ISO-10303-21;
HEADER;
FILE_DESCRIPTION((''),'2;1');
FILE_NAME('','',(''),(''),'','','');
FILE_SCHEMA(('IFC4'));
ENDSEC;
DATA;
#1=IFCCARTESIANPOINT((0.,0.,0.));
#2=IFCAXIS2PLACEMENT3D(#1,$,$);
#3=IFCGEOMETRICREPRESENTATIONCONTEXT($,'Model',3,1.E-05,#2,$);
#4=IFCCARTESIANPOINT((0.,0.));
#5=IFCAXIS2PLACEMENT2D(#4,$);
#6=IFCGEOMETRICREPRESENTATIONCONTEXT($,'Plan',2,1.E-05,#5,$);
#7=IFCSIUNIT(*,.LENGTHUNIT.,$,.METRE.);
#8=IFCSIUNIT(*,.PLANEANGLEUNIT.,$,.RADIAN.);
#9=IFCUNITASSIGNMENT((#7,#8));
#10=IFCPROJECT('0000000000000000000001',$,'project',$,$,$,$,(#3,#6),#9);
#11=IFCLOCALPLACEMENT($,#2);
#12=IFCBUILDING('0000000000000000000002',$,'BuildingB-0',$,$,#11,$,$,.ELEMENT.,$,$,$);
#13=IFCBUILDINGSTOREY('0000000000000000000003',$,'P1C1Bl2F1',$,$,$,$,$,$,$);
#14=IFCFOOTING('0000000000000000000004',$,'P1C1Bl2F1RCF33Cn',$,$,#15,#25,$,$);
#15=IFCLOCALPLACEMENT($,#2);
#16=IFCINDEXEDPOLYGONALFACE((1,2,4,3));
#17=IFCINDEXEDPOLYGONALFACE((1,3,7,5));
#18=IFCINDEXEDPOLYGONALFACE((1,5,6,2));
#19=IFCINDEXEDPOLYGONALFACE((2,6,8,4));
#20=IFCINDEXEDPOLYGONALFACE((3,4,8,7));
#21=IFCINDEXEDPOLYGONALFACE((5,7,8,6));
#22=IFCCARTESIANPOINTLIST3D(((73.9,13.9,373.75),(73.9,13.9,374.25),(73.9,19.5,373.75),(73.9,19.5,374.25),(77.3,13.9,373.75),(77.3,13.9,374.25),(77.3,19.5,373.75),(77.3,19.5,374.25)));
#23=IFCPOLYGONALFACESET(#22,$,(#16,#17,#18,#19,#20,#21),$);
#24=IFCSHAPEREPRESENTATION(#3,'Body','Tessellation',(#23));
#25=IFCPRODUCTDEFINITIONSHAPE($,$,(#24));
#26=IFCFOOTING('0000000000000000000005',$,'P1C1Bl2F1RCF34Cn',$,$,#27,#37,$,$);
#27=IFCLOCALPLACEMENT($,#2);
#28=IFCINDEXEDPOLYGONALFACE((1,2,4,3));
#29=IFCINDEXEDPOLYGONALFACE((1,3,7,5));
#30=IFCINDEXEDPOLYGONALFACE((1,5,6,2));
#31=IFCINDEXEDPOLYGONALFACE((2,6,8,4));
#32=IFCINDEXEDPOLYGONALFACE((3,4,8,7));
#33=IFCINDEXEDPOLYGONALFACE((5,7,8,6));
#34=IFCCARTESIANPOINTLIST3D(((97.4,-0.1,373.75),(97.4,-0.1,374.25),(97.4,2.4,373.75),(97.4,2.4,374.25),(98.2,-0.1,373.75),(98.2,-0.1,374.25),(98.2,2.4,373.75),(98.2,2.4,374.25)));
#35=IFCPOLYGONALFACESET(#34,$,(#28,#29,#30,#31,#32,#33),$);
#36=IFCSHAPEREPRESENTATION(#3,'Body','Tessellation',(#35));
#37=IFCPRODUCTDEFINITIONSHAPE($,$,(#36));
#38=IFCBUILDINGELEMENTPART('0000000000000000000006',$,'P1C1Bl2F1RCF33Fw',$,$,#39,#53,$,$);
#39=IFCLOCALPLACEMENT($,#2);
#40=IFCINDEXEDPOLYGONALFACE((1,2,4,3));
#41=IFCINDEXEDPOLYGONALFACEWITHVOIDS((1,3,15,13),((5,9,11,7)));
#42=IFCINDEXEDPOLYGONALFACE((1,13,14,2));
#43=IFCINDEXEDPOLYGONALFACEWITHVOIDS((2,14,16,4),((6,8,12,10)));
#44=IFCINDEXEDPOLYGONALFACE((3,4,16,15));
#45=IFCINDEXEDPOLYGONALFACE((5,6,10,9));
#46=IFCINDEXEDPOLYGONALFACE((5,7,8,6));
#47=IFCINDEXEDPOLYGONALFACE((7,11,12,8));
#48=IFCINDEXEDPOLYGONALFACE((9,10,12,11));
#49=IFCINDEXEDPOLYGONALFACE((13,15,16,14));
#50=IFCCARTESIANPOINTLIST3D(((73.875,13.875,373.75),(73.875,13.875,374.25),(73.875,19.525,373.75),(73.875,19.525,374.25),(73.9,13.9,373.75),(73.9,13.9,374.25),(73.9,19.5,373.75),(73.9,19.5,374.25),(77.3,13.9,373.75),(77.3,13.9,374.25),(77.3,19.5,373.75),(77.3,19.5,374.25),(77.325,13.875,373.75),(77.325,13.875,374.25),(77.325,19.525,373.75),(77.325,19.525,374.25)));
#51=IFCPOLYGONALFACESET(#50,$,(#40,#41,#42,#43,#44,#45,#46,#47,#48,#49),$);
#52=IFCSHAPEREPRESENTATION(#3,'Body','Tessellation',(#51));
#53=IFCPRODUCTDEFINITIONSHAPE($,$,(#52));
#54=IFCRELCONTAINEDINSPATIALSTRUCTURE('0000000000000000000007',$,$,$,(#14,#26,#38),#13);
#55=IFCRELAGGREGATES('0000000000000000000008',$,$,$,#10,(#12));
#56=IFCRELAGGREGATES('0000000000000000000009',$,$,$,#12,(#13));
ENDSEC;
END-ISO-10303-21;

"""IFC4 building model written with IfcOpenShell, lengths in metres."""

from ifc_helpers import new_model, si_unit, origin, origin_2d, place, context, project, spatial, polyline, outline, extrude, element, save


model = new_model("IFC4")

# Units and contexts
model_context = context("Model", 3, precision=1e-05, world=origin())
plan_context = context("Plan", 2, precision=1e-05, world=origin_2d())
ifc_project = project(units=[si_unit("LENGTHUNIT", "METRE"), si_unit("PLANEANGLEUNIT", "RADIAN")], contexts=[model_context, plan_context])

# Building, storey
building_placement = place(None, origin())
building = spatial("IfcBuilding", under=ifc_project, at=building_placement, Name="BuildingB-0", CompositionType="ELEMENT")
storey = spatial("IfcBuildingStorey", under=building, Name="P1C1Bl2F1")

# Footings
element("IfcFooting", 1, inside=storey, Name="P1C1Bl2F1RCF33Cn", context=model_context, shape_type="SweptSolid", body=[
    extrude(outline(polyline([(73.9, 19.5, 373.75), (77.3, 19.5, 373.75), (77.3, 13.9, 373.75), (73.9, 13.9, 373.75), (73.9, 19.5, 373.75)])), None, (0.0, 0.0, 1.0), 0.5),
])
element("IfcFooting", 2, inside=storey, Name="P1C1Bl2F1RCF34Cn", context=model_context, shape_type="SweptSolid", body=[
    extrude(outline(polyline([(97.4, 2.4, 373.75), (98.2, 2.4, 373.75), (98.2, -0.1, 373.75), (97.4, -0.1, 373.75), (97.4, 2.4, 373.75)])), None, (0.0, 0.0, 1.0), 0.5),
])

# Building element part, opening
building_element_part = element("IfcBuildingElementPart", 3, inside=storey, Name="P1C1Bl2F1RCF33Fw", context=model_context, shape_type="SweptSolid", body=[
    extrude(outline(polyline([(73.875, 19.525, 373.75), (77.325, 19.525, 373.75), (77.325, 13.875, 373.75), (73.875, 13.875, 373.75), (73.875, 19.525, 373.75)])), None, (0.0, 0.0, 1.0), 0.5),
])
element("IfcOpeningElement", 4, inside=storey, cuts=building_element_part, context=model_context, shape_type="SweptSolid", body=[
    extrude(outline(polyline([(73.9, 19.5, 373.75), (77.3, 19.5, 373.75), (77.3, 13.9, 373.75), (73.9, 13.9, 373.75), (73.9, 19.5, 373.75)])), None, (0.0, 0.0, 1.0), 0.5),
])

save(model, "model.ifc")
